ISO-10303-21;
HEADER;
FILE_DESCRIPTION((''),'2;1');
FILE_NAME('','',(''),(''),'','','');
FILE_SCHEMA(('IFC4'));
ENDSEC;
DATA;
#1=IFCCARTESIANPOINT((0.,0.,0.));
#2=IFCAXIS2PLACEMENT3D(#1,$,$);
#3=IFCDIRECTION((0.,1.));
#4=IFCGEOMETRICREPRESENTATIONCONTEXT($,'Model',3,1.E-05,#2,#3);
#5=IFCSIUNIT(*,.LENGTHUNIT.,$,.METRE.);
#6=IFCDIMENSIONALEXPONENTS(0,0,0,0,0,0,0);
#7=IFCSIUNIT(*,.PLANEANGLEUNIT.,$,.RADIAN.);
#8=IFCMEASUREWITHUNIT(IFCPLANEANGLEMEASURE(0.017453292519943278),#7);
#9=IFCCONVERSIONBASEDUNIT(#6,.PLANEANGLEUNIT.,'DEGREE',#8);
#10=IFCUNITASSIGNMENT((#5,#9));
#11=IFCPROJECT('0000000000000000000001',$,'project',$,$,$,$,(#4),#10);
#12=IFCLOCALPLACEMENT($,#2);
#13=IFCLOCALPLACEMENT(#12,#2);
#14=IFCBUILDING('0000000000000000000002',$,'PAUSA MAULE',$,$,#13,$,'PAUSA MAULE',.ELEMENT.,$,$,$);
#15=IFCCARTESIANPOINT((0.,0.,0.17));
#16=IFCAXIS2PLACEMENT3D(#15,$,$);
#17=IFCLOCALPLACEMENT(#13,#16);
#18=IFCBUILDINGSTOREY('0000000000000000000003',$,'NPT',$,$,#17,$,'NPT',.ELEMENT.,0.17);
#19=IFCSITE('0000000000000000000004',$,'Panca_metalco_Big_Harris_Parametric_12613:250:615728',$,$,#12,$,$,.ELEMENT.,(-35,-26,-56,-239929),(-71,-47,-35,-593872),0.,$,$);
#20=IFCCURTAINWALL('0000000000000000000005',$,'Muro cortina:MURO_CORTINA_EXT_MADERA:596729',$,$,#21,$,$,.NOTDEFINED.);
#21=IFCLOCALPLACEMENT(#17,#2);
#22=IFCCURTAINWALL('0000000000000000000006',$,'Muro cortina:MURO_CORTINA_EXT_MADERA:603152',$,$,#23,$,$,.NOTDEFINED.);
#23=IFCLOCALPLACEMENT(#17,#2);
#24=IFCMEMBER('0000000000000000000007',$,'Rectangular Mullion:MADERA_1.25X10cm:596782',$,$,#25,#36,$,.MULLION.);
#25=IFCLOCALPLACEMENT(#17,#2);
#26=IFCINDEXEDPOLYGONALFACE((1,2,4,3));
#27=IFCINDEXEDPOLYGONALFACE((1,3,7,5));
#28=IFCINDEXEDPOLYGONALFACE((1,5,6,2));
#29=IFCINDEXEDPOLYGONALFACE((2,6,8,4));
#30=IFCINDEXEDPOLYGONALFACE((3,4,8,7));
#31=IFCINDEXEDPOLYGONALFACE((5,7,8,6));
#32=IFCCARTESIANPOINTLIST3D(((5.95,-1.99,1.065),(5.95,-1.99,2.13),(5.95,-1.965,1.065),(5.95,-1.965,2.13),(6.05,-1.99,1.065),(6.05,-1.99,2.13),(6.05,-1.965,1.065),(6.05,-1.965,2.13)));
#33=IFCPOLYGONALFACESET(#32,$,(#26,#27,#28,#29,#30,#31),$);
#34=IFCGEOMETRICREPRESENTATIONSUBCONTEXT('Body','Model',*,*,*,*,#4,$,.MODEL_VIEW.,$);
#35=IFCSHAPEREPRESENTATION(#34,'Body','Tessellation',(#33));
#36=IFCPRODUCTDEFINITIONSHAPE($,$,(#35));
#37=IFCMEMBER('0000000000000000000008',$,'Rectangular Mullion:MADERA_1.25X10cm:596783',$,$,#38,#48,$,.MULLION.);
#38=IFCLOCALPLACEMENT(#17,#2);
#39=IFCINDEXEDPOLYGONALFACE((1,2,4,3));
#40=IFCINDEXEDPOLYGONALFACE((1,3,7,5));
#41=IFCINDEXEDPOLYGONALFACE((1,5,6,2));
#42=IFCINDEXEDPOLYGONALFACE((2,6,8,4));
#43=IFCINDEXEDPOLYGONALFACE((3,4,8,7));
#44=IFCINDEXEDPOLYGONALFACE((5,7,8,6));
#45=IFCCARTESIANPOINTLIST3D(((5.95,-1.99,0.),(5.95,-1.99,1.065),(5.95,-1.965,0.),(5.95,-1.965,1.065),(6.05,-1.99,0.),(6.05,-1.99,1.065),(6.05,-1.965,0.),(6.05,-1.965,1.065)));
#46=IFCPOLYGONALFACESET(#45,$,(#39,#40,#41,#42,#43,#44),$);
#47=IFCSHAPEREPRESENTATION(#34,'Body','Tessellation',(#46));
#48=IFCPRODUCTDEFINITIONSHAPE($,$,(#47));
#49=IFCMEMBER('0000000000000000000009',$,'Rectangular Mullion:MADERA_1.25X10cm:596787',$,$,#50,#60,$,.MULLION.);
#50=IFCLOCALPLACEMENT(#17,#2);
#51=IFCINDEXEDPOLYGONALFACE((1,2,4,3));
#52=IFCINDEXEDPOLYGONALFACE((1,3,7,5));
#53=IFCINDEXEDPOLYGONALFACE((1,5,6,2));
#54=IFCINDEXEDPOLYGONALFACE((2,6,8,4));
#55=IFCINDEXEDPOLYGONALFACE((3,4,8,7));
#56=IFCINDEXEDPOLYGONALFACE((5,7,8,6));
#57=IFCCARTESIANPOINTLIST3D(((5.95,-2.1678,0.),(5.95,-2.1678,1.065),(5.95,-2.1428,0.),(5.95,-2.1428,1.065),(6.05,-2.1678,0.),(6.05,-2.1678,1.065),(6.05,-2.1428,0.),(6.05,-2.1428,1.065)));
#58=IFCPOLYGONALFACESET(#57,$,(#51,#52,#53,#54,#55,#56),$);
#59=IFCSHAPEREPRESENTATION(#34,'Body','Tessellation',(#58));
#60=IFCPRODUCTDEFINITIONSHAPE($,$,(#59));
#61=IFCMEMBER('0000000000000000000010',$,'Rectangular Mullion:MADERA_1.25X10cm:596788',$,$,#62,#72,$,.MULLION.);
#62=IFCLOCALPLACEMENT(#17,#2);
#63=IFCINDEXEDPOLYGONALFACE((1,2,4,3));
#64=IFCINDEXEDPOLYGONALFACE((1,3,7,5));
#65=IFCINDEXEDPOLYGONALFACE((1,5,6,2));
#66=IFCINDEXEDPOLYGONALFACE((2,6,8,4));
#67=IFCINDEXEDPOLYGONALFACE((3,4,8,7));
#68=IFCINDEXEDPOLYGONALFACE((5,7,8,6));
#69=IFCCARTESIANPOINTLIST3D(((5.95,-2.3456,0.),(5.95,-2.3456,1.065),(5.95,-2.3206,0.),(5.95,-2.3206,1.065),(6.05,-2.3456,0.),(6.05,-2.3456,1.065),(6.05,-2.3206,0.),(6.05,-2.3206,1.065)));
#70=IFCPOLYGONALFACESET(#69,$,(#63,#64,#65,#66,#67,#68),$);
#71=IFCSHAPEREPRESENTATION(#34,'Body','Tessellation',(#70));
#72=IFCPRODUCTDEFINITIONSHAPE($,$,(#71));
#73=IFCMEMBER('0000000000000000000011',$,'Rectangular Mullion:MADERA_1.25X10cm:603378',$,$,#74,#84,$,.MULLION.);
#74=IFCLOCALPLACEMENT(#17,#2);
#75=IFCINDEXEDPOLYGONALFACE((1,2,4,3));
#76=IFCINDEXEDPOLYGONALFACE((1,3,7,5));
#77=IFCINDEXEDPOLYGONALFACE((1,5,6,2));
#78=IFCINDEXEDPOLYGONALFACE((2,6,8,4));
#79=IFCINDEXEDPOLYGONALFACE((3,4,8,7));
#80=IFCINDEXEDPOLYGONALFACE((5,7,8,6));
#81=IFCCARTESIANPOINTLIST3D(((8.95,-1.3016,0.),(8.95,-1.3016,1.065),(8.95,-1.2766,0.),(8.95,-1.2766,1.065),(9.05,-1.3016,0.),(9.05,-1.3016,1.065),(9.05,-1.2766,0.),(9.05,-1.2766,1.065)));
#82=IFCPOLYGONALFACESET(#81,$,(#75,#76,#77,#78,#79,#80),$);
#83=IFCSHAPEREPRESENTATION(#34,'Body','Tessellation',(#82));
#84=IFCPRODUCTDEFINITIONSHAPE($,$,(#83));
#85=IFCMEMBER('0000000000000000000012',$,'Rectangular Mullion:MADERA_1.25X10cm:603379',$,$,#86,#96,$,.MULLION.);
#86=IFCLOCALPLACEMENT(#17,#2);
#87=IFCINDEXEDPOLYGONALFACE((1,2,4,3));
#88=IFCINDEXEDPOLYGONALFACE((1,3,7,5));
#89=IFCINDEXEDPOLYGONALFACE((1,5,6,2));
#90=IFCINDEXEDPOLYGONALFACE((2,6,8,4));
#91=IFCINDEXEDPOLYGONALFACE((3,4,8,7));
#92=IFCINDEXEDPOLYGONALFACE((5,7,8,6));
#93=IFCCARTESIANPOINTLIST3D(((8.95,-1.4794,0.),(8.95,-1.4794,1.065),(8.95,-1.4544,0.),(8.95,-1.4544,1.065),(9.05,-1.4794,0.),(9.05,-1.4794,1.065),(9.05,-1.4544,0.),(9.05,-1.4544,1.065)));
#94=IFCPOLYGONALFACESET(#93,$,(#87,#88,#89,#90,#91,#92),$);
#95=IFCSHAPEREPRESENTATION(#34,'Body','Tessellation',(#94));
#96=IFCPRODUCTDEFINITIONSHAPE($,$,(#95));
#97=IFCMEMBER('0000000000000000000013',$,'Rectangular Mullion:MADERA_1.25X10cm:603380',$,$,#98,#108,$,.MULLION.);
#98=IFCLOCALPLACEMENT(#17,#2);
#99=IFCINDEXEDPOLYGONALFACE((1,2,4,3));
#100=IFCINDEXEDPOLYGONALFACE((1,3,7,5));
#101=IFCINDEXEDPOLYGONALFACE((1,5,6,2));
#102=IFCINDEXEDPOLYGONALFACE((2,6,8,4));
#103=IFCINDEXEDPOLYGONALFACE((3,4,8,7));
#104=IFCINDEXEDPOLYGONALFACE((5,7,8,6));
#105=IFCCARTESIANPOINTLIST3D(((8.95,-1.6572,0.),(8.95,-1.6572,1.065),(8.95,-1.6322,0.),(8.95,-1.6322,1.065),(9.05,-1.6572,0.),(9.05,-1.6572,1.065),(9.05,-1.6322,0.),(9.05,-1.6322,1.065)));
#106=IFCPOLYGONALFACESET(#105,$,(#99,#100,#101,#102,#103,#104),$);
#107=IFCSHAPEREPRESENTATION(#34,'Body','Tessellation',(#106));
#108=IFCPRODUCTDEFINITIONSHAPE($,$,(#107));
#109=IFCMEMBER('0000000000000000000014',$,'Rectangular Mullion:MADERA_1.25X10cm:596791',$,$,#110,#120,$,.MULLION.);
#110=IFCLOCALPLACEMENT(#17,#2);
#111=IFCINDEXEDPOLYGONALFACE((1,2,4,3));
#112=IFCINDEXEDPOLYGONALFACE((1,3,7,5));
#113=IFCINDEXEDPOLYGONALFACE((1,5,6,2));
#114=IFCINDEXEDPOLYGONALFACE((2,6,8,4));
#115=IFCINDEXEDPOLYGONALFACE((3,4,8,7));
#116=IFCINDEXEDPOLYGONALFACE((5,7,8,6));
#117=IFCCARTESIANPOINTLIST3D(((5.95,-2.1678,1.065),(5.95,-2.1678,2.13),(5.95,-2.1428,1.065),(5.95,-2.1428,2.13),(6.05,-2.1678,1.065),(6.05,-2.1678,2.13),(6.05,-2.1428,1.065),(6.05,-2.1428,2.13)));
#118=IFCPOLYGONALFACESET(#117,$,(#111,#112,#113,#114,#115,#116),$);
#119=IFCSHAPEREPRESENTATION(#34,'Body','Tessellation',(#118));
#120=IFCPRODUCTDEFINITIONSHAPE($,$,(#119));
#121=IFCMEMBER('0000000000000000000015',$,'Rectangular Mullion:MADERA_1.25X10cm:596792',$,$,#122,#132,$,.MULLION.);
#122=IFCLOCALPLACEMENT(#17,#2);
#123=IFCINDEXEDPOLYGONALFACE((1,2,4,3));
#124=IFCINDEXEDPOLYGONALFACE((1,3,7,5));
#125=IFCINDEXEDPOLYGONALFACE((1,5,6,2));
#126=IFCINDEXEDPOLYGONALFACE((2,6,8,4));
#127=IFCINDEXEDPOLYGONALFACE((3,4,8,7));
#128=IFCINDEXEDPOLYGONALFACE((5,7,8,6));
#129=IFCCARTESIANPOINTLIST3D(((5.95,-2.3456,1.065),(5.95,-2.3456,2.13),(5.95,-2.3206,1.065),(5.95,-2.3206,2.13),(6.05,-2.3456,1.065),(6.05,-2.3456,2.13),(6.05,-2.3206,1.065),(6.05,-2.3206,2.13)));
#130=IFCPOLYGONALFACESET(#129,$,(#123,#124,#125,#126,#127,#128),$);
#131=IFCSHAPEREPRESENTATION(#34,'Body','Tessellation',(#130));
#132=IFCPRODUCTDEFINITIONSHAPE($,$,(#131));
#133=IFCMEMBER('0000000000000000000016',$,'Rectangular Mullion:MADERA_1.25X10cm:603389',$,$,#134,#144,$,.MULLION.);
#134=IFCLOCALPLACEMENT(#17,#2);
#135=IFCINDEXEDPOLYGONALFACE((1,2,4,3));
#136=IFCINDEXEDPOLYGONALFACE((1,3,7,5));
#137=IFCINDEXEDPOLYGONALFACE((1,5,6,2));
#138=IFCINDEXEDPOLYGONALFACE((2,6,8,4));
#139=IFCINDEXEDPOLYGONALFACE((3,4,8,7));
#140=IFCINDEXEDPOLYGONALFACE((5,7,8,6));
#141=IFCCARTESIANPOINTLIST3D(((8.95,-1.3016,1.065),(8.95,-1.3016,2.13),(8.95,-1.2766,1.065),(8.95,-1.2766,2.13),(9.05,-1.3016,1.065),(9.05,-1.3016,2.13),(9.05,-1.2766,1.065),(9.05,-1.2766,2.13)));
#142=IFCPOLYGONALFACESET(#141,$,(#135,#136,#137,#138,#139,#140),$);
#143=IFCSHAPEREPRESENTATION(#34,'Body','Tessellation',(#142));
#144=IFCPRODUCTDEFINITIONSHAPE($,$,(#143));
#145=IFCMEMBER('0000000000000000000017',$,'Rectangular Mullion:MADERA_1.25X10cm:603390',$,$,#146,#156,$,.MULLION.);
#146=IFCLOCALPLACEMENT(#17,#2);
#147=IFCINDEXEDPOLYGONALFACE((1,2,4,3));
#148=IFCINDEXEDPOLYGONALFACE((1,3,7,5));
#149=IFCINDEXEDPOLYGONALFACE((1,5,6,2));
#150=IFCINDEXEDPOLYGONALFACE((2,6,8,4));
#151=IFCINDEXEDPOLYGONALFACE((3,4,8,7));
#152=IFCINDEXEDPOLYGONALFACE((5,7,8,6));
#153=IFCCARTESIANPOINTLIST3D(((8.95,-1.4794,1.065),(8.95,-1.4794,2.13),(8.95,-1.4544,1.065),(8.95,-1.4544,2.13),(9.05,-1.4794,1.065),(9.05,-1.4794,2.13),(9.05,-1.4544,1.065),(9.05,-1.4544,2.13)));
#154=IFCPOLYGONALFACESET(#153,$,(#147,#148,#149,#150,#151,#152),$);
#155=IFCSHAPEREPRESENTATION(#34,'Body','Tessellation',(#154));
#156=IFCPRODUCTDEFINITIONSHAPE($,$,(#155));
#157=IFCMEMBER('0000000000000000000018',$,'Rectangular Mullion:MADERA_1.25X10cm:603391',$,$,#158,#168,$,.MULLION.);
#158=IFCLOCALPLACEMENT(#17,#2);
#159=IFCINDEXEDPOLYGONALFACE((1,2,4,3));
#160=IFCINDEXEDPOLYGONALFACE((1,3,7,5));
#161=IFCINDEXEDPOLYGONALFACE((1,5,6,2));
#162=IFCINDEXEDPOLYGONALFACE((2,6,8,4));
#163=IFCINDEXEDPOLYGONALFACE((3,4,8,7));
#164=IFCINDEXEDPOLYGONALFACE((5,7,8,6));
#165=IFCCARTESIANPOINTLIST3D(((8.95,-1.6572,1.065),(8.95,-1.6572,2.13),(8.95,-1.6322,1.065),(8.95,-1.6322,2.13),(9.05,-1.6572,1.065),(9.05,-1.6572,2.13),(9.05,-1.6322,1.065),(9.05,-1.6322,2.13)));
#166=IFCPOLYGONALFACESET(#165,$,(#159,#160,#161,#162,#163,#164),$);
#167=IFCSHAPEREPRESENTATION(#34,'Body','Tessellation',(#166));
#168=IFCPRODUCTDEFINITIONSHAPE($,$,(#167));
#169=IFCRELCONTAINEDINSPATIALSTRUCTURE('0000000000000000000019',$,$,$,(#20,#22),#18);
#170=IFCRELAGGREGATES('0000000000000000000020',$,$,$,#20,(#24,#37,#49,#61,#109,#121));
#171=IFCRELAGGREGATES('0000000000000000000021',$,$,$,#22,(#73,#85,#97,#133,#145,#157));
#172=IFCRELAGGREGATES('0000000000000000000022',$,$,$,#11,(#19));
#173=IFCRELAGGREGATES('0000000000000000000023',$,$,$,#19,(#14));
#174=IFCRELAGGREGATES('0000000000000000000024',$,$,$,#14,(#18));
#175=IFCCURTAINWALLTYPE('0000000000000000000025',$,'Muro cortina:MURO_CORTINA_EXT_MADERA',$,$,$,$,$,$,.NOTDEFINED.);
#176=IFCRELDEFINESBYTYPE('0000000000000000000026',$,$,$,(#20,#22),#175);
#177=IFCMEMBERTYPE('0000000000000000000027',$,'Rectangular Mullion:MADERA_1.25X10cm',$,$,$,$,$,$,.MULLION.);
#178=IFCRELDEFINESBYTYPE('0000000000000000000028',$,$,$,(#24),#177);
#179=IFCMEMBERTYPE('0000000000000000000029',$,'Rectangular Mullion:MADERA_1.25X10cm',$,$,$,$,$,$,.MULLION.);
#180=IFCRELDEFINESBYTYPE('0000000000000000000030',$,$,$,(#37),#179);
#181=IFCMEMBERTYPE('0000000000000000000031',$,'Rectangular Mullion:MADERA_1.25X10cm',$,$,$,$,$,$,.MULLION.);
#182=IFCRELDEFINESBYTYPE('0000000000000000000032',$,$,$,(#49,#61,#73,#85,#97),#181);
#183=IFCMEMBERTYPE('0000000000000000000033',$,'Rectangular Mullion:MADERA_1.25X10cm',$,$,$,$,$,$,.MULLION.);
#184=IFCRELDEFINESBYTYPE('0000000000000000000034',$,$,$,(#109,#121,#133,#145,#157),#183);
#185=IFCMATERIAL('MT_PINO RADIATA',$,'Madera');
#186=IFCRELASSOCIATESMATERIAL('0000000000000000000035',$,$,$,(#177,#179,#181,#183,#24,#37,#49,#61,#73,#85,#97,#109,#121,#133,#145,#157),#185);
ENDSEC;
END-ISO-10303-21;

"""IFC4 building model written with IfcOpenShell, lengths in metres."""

from ifc_helpers import new_model, entity, si_unit, converted_unit, direction, frame, frame_2d, origin, place, context, subcontext, project, spatial, rectangle, extrude, source, transform, mapped, material, material_profile, profile_set, profile_usage, type_object, type_shapes, element, aggregate, save


model = new_model("IFC4")

# Units and contexts
model_context = context("Model", 3, precision=1e-05, world=origin(), true_north=direction((0.0, 1.0)))
body_context = subcontext(model_context, "Body", "Model", "MODEL_VIEW")
ifc_project = project(units=[si_unit("LENGTHUNIT", "METRE"), converted_unit("PLANEANGLEUNIT", "DEGREE", entity("IfcPlaneAngleMeasure", 0.017453292519943278), si_unit("PLANEANGLEUNIT", "RADIAN"), dimensions=[0, 0, 0, 0, 0, 0, 0])], contexts=[model_context])

# Site, building, storey
site_placement = place(None, origin())
site = spatial("IfcSite", under=ifc_project, at=site_placement, Name="Panca_metalco_Big_Harris_Parametric_12613:250:615728", CompositionType="ELEMENT", RefLatitude=(-35, -26, -56, -239929), RefLongitude=(-71, -47, -35, -593872), RefElevation=0.0)
building_placement = place(site_placement, origin())
building = spatial("IfcBuilding", under=site, at=building_placement, Name="PAUSA MAULE", LongName="PAUSA MAULE", CompositionType="ELEMENT")
storey_placement = place(building_placement, frame((0.0, 0.0, 0.17)))
storey = spatial("IfcBuildingStorey", under=building, at=storey_placement, Name="NPT", LongName="NPT", CompositionType="ELEMENT", Elevation=0.17)

# Curtain walls
curtain_wall_type = type_object("IfcCurtainWallType", Name="Muro cortina:MURO_CORTINA_EXT_MADERA", PredefinedType="NOTDEFINED")
curtain_wall_1_placement = place(storey_placement, frame((0.0, 0.0, -0.17)))
curtain_wall_1 = element("IfcCurtainWall", 1, at=curtain_wall_1_placement, inside=storey, type_object=curtain_wall_type, Name="Muro cortina:MURO_CORTINA_EXT_MADERA:596729", PredefinedType="NOTDEFINED")
ifc_material = material(Name="MT_PINO RADIATA", Category="Madera")
ifc_material_profile = material_profile(ifc_material, rectangle(XDim=0.025, YDim=0.1, at=frame_2d((0.0, 0.0), x_axis=(1.0, 0.0))), Name="MADERA_1.25X10cm")
ifc_profile_set = profile_set([ifc_material_profile], Name="MADERA_1.25X10cm")
ifc_profile_usage = profile_usage(ifc_profile_set)
curtain_wall_2_placement = place(storey_placement, frame((0.0, 0.0, -0.17)))
curtain_wall_2 = element("IfcCurtainWall", 2, at=curtain_wall_2_placement, inside=storey, type_object=curtain_wall_type, Name="Muro cortina:MURO_CORTINA_EXT_MADERA:603152", PredefinedType="NOTDEFINED")

# Members
member_type_1 = type_object("IfcMemberType", Name="Rectangular Mullion:MADERA_1.25X10cm", PredefinedType="MULLION", material=ifc_profile_set)
shared_shape_1 = source(origin(), body_context, "Body", "SweptSolid", [
    extrude(rectangle(XDim=0.025, YDim=0.1, at=frame_2d((0.0, 0.0), x_axis=(1.0, 0.0))), frame((-0.0125, 0.0, -1.065), z_axis=(0.0, 0.0, 1.0), x_axis=(-1.0, 0.0, 0.0)), (0.0, 0.0, 1.0), 1.065),
])
type_shapes(member_type_1, [shared_shape_1])
member_1_placement = place(curtain_wall_1_placement, frame((6.0, -1.965, 2.3), z_axis=(0.0, 0.0, 1.0), x_axis=(0.0, 1.0, 0.0)))
member_1 = element("IfcMember", 3, at=member_1_placement, type_object=member_type_1, material=ifc_profile_usage, Name="Rectangular Mullion:MADERA_1.25X10cm:596782", PredefinedType="MULLION", context=body_context, shape_type="MappedRepresentation", body=[
    mapped(shared_shape_1, transform((0.0, 0.0, 0.0), scale=1.0)),
])
member_type_2 = type_object("IfcMemberType", Name="Rectangular Mullion:MADERA_1.25X10cm", PredefinedType="MULLION", material=ifc_profile_set)
shared_shape_2 = source(origin(), body_context, "Body", "SweptSolid", [
    extrude(rectangle(XDim=0.025, YDim=0.1, at=frame_2d((0.0, 0.0), x_axis=(1.0, 0.0))), frame((-0.0125, 0.0, -1.065), z_axis=(0.0, 0.0, 1.0), x_axis=(-1.0, 0.0, 0.0)), (0.0, 0.0, 1.0), 1.065),
])
type_shapes(member_type_2, [shared_shape_2])
member_2_placement = place(curtain_wall_1_placement, frame((6.0, -1.965, 1.235), z_axis=(0.0, 0.0, 1.0), x_axis=(0.0, 1.0, 0.0)))
member_2 = element("IfcMember", 4, at=member_2_placement, type_object=member_type_2, material=ifc_profile_usage, Name="Rectangular Mullion:MADERA_1.25X10cm:596783", PredefinedType="MULLION", context=body_context, shape_type="MappedRepresentation", body=[
    mapped(shared_shape_2, transform((0.0, 0.0, 0.0), scale=1.0)),
])
member_type_3 = type_object("IfcMemberType", Name="Rectangular Mullion:MADERA_1.25X10cm", PredefinedType="MULLION", material=ifc_profile_set)
shared_shape_3 = source(origin(), body_context, "Body", "SweptSolid", [
    extrude(rectangle(XDim=0.025, YDim=0.1, at=frame_2d((0.0, 0.0), x_axis=(1.0, 0.0))), frame((0.0, 0.0, -1.065), z_axis=(0.0, 0.0, 1.0), x_axis=(-1.0, 0.0, 0.0)), (0.0, 0.0, 1.0), 1.065),
])
type_shapes(member_type_3, [shared_shape_3])
member_3_placement = place(curtain_wall_1_placement, frame((6.0, -2.1553, 0.17), z_axis=(0.0, 0.0, -1.0), x_axis=(0.0, -1.0, 0.0)))
member_3 = element("IfcMember", 5, at=member_3_placement, type_object=member_type_3, material=ifc_profile_usage, Name="Rectangular Mullion:MADERA_1.25X10cm:596787", PredefinedType="MULLION", context=body_context, shape_type="MappedRepresentation", body=[
    mapped(shared_shape_3, transform((0.0, 0.0, 0.0), scale=1.0)),
])
member_4_placement = place(curtain_wall_1_placement, frame((6.0, -2.3331, 0.17), z_axis=(0.0, 0.0, -1.0), x_axis=(0.0, -1.0, 0.0)))
member_4 = element("IfcMember", 6, at=member_4_placement, type_object=member_type_3, material=ifc_profile_usage, Name="Rectangular Mullion:MADERA_1.25X10cm:596788", PredefinedType="MULLION", context=body_context, shape_type="MappedRepresentation", body=[
    mapped(shared_shape_3, transform((0.0, 0.0, 0.0), scale=1.0)),
])
member_5_placement = place(curtain_wall_2_placement, frame((9.0, -1.2891, 0.17), z_axis=(0.0, 0.0, -1.0), x_axis=(0.0, -1.0, 0.0)))
member_5 = element("IfcMember", 7, at=member_5_placement, type_object=member_type_3, material=ifc_profile_usage, Name="Rectangular Mullion:MADERA_1.25X10cm:603378", PredefinedType="MULLION", context=body_context, shape_type="MappedRepresentation", body=[
    mapped(shared_shape_3, transform((0.0, 0.0, 0.0), scale=1.0)),
])
member_6_placement = place(curtain_wall_2_placement, frame((9.0, -1.4669, 0.17), z_axis=(0.0, 0.0, -1.0), x_axis=(0.0, -1.0, 0.0)))
member_6 = element("IfcMember", 8, at=member_6_placement, type_object=member_type_3, material=ifc_profile_usage, Name="Rectangular Mullion:MADERA_1.25X10cm:603379", PredefinedType="MULLION", context=body_context, shape_type="MappedRepresentation", body=[
    mapped(shared_shape_3, transform((0.0, 0.0, 0.0), scale=1.0)),
])
member_7_placement = place(curtain_wall_2_placement, frame((9.0, -1.6447, 0.17), z_axis=(0.0, 0.0, -1.0), x_axis=(0.0, -1.0, 0.0)))
member_7 = element("IfcMember", 9, at=member_7_placement, type_object=member_type_3, material=ifc_profile_usage, Name="Rectangular Mullion:MADERA_1.25X10cm:603380", PredefinedType="MULLION", context=body_context, shape_type="MappedRepresentation", body=[
    mapped(shared_shape_3, transform((0.0, 0.0, 0.0), scale=1.0)),
])
member_type_4 = type_object("IfcMemberType", Name="Rectangular Mullion:MADERA_1.25X10cm", PredefinedType="MULLION", material=ifc_profile_set)
shared_shape_4 = source(origin(), body_context, "Body", "SweptSolid", [
    extrude(rectangle(XDim=0.025, YDim=0.1, at=frame_2d((0.0, 0.0), x_axis=(1.0, 0.0))), frame((0.0, 0.0, -1.065), z_axis=(0.0, 0.0, 1.0), x_axis=(-1.0, 0.0, 0.0)), (0.0, 0.0, 1.0), 1.065),
])
type_shapes(member_type_4, [shared_shape_4])
member_8_placement = place(curtain_wall_1_placement, frame((6.0, -2.1553, 1.235), z_axis=(0.0, 0.0, -1.0), x_axis=(0.0, -1.0, 0.0)))
member_8 = element("IfcMember", 10, at=member_8_placement, type_object=member_type_4, material=ifc_profile_usage, Name="Rectangular Mullion:MADERA_1.25X10cm:596791", PredefinedType="MULLION", context=body_context, shape_type="MappedRepresentation", body=[
    mapped(shared_shape_4, transform((0.0, 0.0, 0.0), scale=1.0)),
])
member_9_placement = place(curtain_wall_1_placement, frame((6.0, -2.3331, 1.235), z_axis=(0.0, 0.0, -1.0), x_axis=(0.0, -1.0, 0.0)))
member_9 = element("IfcMember", 11, at=member_9_placement, type_object=member_type_4, material=ifc_profile_usage, Name="Rectangular Mullion:MADERA_1.25X10cm:596792", PredefinedType="MULLION", context=body_context, shape_type="MappedRepresentation", body=[
    mapped(shared_shape_4, transform((0.0, 0.0, 0.0), scale=1.0)),
])
aggregate(curtain_wall_1, [member_1, member_2, member_3, member_4, member_8, member_9])
member_10_placement = place(curtain_wall_2_placement, frame((9.0, -1.2891, 1.235), z_axis=(0.0, 0.0, -1.0), x_axis=(0.0, -1.0, 0.0)))
member_10 = element("IfcMember", 12, at=member_10_placement, type_object=member_type_4, material=ifc_profile_usage, Name="Rectangular Mullion:MADERA_1.25X10cm:603389", PredefinedType="MULLION", context=body_context, shape_type="MappedRepresentation", body=[
    mapped(shared_shape_4, transform((0.0, 0.0, 0.0), scale=1.0)),
])
member_11_placement = place(curtain_wall_2_placement, frame((9.0, -1.4669, 1.235), z_axis=(0.0, 0.0, -1.0), x_axis=(0.0, -1.0, 0.0)))
member_11 = element("IfcMember", 13, at=member_11_placement, type_object=member_type_4, material=ifc_profile_usage, Name="Rectangular Mullion:MADERA_1.25X10cm:603390", PredefinedType="MULLION", context=body_context, shape_type="MappedRepresentation", body=[
    mapped(shared_shape_4, transform((0.0, 0.0, 0.0), scale=1.0)),
])
member_12_placement = place(curtain_wall_2_placement, frame((9.0, -1.6447, 1.235), z_axis=(0.0, 0.0, -1.0), x_axis=(0.0, -1.0, 0.0)))
member_12 = element("IfcMember", 14, at=member_12_placement, type_object=member_type_4, material=ifc_profile_usage, Name="Rectangular Mullion:MADERA_1.25X10cm:603391", PredefinedType="MULLION", context=body_context, shape_type="MappedRepresentation", body=[
    mapped(shared_shape_4, transform((0.0, 0.0, 0.0), scale=1.0)),
])
aggregate(curtain_wall_2, [member_5, member_6, member_7, member_10, member_11, member_12])

save(model, "model.ifc")
